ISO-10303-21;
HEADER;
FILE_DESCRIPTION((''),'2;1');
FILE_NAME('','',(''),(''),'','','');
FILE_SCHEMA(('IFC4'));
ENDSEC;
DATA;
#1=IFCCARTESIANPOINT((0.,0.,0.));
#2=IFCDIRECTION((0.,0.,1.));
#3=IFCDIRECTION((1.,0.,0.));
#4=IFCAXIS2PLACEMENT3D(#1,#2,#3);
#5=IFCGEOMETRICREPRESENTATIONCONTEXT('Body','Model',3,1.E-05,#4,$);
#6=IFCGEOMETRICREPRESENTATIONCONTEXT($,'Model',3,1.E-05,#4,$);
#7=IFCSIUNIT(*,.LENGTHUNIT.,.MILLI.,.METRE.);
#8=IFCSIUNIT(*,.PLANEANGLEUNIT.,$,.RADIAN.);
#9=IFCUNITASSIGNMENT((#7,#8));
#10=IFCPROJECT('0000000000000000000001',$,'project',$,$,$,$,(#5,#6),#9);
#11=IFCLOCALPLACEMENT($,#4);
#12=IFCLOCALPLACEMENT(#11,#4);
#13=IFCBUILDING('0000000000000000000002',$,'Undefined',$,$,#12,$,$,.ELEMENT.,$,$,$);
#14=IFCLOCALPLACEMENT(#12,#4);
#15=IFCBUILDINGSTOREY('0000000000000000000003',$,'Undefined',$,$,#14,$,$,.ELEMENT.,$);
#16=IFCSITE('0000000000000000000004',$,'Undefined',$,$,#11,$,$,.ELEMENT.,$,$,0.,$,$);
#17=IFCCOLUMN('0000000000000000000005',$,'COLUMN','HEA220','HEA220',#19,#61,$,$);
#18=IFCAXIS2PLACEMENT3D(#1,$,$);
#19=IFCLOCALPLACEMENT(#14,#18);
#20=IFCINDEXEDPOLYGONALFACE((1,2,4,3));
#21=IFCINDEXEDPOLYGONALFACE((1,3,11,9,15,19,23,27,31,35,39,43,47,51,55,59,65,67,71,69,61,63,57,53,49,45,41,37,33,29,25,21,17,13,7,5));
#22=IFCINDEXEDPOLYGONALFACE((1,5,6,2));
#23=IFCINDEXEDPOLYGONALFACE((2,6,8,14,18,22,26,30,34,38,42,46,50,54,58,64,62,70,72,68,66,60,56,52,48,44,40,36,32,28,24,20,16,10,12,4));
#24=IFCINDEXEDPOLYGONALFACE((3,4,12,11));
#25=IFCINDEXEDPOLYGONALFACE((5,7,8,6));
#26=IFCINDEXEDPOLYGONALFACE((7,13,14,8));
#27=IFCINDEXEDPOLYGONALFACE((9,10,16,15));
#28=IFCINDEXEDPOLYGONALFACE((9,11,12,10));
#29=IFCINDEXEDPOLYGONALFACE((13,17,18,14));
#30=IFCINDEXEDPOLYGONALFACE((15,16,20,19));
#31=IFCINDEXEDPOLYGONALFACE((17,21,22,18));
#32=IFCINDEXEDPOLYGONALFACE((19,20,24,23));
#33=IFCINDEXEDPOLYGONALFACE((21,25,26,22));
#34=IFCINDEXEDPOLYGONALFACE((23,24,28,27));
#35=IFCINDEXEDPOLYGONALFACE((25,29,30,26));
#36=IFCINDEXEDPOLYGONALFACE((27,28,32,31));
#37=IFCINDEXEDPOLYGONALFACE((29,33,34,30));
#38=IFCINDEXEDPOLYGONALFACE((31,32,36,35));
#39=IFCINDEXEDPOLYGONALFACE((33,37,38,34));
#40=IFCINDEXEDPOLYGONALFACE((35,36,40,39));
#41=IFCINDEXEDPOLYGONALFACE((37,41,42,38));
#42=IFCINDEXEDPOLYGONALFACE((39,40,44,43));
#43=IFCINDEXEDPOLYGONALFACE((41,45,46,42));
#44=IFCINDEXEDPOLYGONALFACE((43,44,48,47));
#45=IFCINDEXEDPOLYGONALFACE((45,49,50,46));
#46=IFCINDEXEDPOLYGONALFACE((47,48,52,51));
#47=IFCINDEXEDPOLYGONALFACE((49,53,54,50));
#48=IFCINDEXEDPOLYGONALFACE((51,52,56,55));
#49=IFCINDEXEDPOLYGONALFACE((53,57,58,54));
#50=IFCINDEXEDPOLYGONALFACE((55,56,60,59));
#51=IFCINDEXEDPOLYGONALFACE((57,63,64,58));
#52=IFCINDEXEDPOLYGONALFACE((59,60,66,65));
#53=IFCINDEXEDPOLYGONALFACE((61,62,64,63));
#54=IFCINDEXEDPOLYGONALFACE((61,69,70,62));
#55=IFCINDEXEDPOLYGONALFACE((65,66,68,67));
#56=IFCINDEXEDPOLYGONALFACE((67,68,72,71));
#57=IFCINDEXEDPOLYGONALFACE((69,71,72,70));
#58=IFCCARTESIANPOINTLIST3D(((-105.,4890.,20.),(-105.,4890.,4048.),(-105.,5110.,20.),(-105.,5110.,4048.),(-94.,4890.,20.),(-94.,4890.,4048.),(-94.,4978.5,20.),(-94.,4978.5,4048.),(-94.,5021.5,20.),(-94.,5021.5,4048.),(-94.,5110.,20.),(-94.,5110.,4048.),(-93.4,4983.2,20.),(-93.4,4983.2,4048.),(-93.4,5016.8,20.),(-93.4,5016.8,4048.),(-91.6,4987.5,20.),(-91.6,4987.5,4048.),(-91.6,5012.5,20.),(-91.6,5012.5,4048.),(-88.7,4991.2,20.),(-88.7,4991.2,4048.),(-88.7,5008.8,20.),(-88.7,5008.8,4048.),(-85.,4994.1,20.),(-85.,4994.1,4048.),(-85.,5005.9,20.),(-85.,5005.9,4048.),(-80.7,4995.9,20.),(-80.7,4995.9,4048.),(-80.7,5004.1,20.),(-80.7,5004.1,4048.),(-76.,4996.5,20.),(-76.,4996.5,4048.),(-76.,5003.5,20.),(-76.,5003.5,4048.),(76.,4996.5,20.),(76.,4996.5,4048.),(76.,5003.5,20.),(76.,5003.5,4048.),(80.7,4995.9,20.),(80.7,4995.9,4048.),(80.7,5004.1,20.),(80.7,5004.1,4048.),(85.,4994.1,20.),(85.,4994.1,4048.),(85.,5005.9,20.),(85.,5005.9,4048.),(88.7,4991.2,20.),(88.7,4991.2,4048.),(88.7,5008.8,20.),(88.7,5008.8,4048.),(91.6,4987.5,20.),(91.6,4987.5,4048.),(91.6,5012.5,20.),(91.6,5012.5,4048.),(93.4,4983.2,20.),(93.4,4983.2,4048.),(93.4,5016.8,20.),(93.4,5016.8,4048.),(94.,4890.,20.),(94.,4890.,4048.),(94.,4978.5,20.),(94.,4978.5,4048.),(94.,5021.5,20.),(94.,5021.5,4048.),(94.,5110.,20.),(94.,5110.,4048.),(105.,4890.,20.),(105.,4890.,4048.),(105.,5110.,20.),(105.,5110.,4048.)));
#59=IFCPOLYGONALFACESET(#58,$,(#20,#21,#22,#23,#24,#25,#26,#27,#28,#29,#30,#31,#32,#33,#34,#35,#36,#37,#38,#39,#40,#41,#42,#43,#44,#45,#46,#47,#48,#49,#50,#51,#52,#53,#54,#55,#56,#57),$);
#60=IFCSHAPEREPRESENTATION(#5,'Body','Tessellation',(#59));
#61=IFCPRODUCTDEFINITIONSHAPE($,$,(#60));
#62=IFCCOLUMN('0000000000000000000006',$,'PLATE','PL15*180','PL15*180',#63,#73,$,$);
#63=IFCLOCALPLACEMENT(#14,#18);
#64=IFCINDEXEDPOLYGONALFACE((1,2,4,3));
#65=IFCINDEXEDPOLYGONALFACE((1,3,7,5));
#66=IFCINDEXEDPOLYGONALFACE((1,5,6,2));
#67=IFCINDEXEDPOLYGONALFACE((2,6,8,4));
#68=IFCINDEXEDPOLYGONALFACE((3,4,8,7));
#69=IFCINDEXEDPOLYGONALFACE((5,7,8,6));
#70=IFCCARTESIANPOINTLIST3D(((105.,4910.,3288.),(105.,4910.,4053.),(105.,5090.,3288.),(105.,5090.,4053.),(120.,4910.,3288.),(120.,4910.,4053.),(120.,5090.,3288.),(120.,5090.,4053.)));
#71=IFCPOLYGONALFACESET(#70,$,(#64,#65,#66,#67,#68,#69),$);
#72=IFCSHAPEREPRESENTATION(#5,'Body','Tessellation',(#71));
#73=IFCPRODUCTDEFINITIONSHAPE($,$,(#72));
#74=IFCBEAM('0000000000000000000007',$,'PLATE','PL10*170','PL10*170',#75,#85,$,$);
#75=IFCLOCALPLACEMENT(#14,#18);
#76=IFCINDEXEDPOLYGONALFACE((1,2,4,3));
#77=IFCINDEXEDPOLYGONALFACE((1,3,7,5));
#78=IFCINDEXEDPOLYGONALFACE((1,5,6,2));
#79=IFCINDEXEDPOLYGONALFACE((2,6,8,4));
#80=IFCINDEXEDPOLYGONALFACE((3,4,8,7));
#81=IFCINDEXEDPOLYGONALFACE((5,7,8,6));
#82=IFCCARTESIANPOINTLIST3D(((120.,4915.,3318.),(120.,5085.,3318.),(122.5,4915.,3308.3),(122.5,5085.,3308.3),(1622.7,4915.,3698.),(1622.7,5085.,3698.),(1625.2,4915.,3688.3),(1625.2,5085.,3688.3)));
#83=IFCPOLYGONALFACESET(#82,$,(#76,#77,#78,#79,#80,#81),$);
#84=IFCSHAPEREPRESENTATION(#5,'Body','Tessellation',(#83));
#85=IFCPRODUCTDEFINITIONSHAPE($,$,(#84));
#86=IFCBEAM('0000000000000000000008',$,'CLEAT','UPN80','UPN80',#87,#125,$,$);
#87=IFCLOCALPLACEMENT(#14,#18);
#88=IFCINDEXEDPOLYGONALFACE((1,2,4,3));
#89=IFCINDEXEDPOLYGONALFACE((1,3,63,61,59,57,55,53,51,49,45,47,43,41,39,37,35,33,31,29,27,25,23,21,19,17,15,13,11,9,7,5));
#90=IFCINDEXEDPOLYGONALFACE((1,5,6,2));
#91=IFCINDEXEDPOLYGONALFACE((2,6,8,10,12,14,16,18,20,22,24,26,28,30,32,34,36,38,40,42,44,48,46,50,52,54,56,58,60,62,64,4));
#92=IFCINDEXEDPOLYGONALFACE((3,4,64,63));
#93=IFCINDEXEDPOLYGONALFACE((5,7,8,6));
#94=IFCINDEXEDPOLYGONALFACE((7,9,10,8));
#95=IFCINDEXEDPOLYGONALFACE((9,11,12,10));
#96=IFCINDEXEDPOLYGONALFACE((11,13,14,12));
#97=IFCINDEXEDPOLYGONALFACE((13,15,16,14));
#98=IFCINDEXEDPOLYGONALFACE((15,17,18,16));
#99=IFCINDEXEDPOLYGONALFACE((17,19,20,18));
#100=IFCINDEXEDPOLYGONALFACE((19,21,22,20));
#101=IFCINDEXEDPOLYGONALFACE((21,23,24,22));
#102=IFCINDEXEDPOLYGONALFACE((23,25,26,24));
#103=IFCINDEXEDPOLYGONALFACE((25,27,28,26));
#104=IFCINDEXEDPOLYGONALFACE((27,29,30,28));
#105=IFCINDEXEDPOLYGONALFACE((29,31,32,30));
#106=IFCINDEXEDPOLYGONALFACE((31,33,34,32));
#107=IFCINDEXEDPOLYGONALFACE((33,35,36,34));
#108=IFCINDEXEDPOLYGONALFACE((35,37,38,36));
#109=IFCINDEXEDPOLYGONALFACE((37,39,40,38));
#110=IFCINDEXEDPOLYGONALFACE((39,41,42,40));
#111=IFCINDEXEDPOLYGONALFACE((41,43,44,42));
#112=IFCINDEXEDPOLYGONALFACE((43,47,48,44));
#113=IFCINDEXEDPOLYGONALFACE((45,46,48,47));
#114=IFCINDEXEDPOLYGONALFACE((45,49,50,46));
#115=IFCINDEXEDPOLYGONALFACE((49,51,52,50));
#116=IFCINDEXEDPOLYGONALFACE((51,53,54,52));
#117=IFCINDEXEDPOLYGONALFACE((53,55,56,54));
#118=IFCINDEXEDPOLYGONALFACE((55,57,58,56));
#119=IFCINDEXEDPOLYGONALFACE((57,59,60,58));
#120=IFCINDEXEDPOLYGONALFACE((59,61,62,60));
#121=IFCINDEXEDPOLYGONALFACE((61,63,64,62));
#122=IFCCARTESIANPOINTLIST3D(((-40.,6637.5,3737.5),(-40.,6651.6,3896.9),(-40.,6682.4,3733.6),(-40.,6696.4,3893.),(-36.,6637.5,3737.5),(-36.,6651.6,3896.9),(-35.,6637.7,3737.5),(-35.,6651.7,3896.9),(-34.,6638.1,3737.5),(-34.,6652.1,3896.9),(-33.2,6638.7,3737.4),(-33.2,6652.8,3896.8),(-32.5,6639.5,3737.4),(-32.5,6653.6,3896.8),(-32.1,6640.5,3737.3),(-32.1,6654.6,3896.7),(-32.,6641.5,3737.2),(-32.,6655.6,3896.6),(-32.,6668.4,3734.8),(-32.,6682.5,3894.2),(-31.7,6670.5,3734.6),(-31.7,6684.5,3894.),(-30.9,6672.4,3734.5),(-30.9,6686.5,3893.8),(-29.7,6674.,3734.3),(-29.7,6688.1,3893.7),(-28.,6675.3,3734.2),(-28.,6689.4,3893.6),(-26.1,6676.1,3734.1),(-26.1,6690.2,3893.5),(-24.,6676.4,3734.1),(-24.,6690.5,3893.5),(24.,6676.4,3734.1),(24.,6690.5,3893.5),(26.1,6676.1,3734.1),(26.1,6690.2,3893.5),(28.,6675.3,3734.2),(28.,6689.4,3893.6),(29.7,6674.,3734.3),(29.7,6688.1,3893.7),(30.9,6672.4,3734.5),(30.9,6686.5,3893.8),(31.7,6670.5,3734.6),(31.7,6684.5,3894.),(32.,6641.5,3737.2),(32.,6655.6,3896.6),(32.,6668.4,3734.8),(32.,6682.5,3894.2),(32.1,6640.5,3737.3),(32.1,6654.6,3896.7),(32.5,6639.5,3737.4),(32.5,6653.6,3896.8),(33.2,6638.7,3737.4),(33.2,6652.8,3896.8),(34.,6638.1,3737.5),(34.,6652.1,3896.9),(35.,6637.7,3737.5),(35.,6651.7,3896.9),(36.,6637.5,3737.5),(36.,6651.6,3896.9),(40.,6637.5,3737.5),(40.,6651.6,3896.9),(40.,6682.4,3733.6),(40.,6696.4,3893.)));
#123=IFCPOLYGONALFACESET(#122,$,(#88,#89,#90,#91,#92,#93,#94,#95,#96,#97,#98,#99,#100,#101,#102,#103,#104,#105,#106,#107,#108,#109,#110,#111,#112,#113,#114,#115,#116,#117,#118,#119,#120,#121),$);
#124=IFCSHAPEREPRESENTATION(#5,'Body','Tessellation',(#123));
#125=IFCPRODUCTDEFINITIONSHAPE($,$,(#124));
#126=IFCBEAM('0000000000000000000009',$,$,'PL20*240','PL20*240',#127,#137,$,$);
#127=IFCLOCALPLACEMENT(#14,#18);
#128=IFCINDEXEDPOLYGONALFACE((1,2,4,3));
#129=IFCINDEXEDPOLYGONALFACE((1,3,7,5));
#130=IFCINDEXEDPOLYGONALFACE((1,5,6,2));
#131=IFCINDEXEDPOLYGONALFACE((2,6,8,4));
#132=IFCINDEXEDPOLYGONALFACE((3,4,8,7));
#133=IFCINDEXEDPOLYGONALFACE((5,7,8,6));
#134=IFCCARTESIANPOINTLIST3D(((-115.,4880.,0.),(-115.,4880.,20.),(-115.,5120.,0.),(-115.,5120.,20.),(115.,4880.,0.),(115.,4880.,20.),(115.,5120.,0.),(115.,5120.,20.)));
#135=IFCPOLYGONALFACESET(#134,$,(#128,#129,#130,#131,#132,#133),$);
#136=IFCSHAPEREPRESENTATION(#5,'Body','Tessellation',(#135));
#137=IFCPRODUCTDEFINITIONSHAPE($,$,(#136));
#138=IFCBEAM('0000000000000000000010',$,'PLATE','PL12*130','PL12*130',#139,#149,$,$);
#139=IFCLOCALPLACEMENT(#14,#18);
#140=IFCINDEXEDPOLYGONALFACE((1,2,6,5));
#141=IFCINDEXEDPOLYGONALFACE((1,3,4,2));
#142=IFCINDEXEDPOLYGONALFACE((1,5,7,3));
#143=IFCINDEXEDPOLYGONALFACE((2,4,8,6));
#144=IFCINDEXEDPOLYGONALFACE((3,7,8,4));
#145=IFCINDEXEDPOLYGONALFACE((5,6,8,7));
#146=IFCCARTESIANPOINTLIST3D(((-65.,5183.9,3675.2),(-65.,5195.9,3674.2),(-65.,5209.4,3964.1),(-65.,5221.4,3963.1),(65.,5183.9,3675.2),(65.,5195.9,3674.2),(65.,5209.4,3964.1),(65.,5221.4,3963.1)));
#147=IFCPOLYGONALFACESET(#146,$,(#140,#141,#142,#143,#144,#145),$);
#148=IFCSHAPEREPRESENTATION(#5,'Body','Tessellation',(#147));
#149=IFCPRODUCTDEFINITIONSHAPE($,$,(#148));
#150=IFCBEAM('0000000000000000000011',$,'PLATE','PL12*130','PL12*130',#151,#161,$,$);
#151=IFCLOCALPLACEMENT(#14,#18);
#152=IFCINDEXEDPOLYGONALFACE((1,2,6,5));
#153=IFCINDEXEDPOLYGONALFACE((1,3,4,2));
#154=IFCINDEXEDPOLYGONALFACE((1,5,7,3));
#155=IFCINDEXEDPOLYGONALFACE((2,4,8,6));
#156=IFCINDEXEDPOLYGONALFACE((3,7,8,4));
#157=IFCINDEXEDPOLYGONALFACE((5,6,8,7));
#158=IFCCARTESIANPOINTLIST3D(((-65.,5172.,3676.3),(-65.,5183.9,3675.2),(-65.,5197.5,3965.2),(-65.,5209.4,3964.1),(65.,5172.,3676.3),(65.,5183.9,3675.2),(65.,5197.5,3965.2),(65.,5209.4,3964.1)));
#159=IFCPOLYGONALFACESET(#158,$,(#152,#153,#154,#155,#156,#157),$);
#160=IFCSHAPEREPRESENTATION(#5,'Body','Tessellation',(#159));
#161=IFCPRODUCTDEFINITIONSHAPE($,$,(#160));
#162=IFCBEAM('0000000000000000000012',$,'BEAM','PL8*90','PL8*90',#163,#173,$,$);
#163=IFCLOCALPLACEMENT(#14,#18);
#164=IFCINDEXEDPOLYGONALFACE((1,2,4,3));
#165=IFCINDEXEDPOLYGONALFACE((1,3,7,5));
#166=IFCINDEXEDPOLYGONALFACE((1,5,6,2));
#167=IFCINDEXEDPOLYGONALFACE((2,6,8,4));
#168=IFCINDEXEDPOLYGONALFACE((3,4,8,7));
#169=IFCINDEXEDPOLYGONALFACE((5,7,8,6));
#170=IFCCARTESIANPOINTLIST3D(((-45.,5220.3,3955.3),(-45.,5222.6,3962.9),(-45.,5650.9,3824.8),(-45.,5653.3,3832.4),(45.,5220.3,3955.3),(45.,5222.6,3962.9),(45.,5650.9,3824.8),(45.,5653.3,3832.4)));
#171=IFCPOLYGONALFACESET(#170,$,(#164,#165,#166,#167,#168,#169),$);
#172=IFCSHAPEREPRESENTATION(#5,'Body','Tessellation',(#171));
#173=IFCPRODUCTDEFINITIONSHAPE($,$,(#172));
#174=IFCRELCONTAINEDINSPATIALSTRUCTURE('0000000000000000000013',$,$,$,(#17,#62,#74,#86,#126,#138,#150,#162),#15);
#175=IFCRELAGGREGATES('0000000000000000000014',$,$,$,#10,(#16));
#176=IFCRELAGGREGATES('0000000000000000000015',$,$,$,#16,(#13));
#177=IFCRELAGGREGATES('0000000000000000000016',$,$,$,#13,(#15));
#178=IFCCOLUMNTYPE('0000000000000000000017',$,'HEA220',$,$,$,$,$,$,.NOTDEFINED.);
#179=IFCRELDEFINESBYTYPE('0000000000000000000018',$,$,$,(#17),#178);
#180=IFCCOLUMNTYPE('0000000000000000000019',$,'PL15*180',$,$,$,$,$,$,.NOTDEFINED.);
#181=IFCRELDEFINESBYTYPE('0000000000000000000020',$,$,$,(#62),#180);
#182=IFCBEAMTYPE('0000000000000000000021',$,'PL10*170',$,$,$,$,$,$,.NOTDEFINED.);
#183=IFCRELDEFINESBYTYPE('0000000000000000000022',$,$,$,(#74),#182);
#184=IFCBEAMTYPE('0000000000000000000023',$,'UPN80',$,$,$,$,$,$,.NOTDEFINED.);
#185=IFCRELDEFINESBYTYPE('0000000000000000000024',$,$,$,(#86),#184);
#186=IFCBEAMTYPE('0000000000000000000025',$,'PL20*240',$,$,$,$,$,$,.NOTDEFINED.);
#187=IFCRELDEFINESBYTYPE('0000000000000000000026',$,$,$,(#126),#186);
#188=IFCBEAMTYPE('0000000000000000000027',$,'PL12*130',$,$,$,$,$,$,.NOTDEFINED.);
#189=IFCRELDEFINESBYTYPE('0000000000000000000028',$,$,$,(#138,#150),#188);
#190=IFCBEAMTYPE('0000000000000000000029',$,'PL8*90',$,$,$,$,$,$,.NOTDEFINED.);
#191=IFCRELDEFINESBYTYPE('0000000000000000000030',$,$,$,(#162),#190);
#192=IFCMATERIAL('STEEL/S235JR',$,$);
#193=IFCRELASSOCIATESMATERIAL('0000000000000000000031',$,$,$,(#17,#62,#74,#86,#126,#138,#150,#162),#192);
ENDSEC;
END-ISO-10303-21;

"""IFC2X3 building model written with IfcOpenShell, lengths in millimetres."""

from ifc_helpers import new_model, si_unit, frame, origin_with_axes, origin_2d_with_axis, place, context, project, spatial, rectangle, i_section, u_section, extrude, material, type_object, element, save


model = new_model("IFC2X3")

# Units and contexts
model_context_1 = context("Model", 3, precision=1e-05, world=origin_with_axes(), identifier="Body")
model_context_2 = context("Model", 3, precision=1e-05, world=origin_with_axes())
ifc_project = project(units=[si_unit("LENGTHUNIT", "METRE", prefix="MILLI"), si_unit("PLANEANGLEUNIT", "RADIAN")], contexts=[model_context_1, model_context_2])

# Site, building, storey
site_placement = place(None, origin_with_axes())
site = spatial("IfcSite", under=ifc_project, at=site_placement, Name="Undefined", CompositionType="ELEMENT", RefElevation=0.0)
building_placement = place(site_placement, origin_with_axes())
building = spatial("IfcBuilding", under=site, at=building_placement, Name="Undefined", CompositionType="ELEMENT")
storey_placement = place(building_placement, origin_with_axes())
storey = spatial("IfcBuildingStorey", under=building, at=storey_placement, Name="Undefined", CompositionType="ELEMENT")

# Columns
ifc_material = material(Name="STEEL/S235JR")
column_type_1 = type_object("IfcColumnType", Name="HEA220", PredefinedType="NOTDEFINED")
column_1_placement = place(storey_placement, frame((0.0, 5000.0, 0.0), z_axis=(0.0, 0.0, 1.0), x_axis=(1.0, 0.0, 0.0)))
element("IfcColumn", 1, at=column_1_placement, inside=storey, type_object=column_type_1, material=ifc_material, Name="COLUMN", Description="HEA220", ObjectType="HEA220", context=model_context_1, shape_type="SweptSolid", body=[
    extrude(i_section(OverallWidth=220.0, OverallDepth=210.0, WebThickness=7.0, FlangeThickness=11.0, FilletRadius=18.0, at=origin_2d_with_axis()), frame((0.0, 0.0, 4048.0), z_axis=(0.0, 0.0, -1.0), x_axis=(0.0, 1.0, 0.0)), (0.0, 0.0, 1.0), 4028.0),
])
column_type_2 = type_object("IfcColumnType", Name="PL15*180", PredefinedType="NOTDEFINED")
column_2_placement = place(storey_placement, frame((112.5, 5000.0, 3288.0), z_axis=(0.0, 0.0, 1.0), x_axis=(1.0, 0.0, 0.0)))
element("IfcColumn", 2, at=column_2_placement, inside=storey, type_object=column_type_2, material=ifc_material, Name="PLATE", Description="PL15*180", ObjectType="PL15*180", context=model_context_1, shape_type="SweptSolid", body=[
    extrude(rectangle(XDim=15.0, YDim=180.0, at=origin_2d_with_axis()), frame((0.0, 0.0, 765.0), z_axis=(0.0, 0.0, -1.0), x_axis=(1.0, 0.0, 0.0)), (0.0, 0.0, 1.0), 765.0),
])

# Beams
beam_type_1 = type_object("IfcBeamType", Name="PL10*170", PredefinedType="NOTDEFINED")
beam_1_placement = place(storey_placement, frame((121.2, 5000.0, 3313.2), z_axis=(0.0, -1.0, 0.0), x_axis=(0.969482, 0.0, 0.245161)))
element("IfcBeam", 3, at=beam_1_placement, inside=storey, type_object=beam_type_1, material=ifc_material, Name="PLATE", Description="PL10*170", ObjectType="PL10*170", context=model_context_1, shape_type="SweptSolid", body=[
    extrude(rectangle(XDim=10.0, YDim=170.0, at=origin_2d_with_axis()), frame((1550.0, 0.0, 0.0), z_axis=(-1.0, 0.0, 0.0), x_axis=(0.0, -1.0, 0.0)), (0.0, 0.0, 1.0), 1550.0),
])
beam_type_2 = type_object("IfcBeamType", Name="UPN80", PredefinedType="NOTDEFINED")
beam_2_placement = place(storey_placement, frame((0.0, 6659.9, 3735.6), z_axis=(-1.0, 0.0, 0.0), x_axis=(0.0, 0.08801, 0.99612)))
element("IfcBeam", 4, at=beam_2_placement, inside=storey, type_object=beam_type_2, material=ifc_material, Name="CLEAT", Description="UPN80", ObjectType="UPN80", context=model_context_1, shape_type="SweptSolid", body=[
    extrude(u_section(Depth=80.0, FlangeWidth=45.0, WebThickness=6.0, FlangeThickness=8.0, FilletRadius=8.0, EdgeRadius=4.0, at=origin_2d_with_axis()), frame((160.0, 0.0, 0.0), z_axis=(-1.0, 0.0, 0.0), x_axis=(0.0, -1.0, 0.0)), (0.0, 0.0, 1.0), 160.0),
])
beam_type_3 = type_object("IfcBeamType", Name="PL20*240", PredefinedType="NOTDEFINED")
beam_3_placement = place(storey_placement, frame((-115.0, 5000.0, 10.0), z_axis=(0.0, 1.0, 0.0), x_axis=(1.0, 0.0, 0.0)))
element("IfcBeam", 5, at=beam_3_placement, inside=storey, type_object=beam_type_3, material=ifc_material, Description="PL20*240", ObjectType="PL20*240", context=model_context_1, shape_type="SweptSolid", body=[
    extrude(rectangle(XDim=20.0, YDim=240.0, at=origin_2d_with_axis()), frame((230.0, 0.0, 0.0), z_axis=(-1.0, 0.0, 0.0), x_axis=(0.0, -1.0, 0.0)), (0.0, 0.0, 1.0), 230.0),
])
beam_type_4 = type_object("IfcBeamType", Name="PL12*130", PredefinedType="NOTDEFINED")
beam_4_placement = place(storey_placement, frame((0.0, 5189.9, 3674.7), z_axis=(-1.0, 0.0, 0.0), x_axis=(0.0, 0.08801, 0.99612)))
element("IfcBeam", 6, at=beam_4_placement, inside=storey, type_object=beam_type_4, material=ifc_material, Name="PLATE", Description="PL12*130", ObjectType="PL12*130", context=model_context_1, shape_type="SweptSolid", body=[
    extrude(rectangle(XDim=12.0, YDim=130.0, at=origin_2d_with_axis()), frame((290.0, 0.0, 0.0), z_axis=(-1.0, 0.0, 0.0), x_axis=(0.0, -1.0, 0.0)), (0.0, 0.0, 1.0), 290.0),
])
beam_5_placement = place(storey_placement, frame((0.0, 5177.9, 3675.8), z_axis=(-1.0, 0.0, 0.0), x_axis=(0.0, 0.08801, 0.99612)))
element("IfcBeam", 7, at=beam_5_placement, inside=storey, type_object=beam_type_4, material=ifc_material, Name="PLATE", Description="PL12*130", ObjectType="PL12*130", context=model_context_1, shape_type="SweptSolid", body=[
    extrude(rectangle(XDim=12.0, YDim=130.0, at=origin_2d_with_axis()), frame((290.0, 0.0, 0.0), z_axis=(-1.0, 0.0, 0.0), x_axis=(0.0, -1.0, 0.0)), (0.0, 0.0, 1.0), 290.0),
])
beam_type_5 = type_object("IfcBeamType", Name="PL8*90", PredefinedType="NOTDEFINED")
beam_6_placement = place(storey_placement, frame((0.0, 5221.4, 3959.1), z_axis=(-1.0, 0.0, 0.0), x_axis=(0.0, 0.957026, -0.290002)))
element("IfcBeam", 8, at=beam_6_placement, inside=storey, type_object=beam_type_5, material=ifc_material, Name="BEAM", Description="PL8*90", ObjectType="PL8*90", context=model_context_1, shape_type="SweptSolid", body=[
    extrude(rectangle(XDim=8.0, YDim=90.0, at=origin_2d_with_axis()), frame((450.0, 0.0, 0.0), z_axis=(-1.0, 0.0, 0.0), x_axis=(0.0, -1.0, 0.0)), (0.0, 0.0, 1.0), 450.0),
])

save(model, "model.ifc")
